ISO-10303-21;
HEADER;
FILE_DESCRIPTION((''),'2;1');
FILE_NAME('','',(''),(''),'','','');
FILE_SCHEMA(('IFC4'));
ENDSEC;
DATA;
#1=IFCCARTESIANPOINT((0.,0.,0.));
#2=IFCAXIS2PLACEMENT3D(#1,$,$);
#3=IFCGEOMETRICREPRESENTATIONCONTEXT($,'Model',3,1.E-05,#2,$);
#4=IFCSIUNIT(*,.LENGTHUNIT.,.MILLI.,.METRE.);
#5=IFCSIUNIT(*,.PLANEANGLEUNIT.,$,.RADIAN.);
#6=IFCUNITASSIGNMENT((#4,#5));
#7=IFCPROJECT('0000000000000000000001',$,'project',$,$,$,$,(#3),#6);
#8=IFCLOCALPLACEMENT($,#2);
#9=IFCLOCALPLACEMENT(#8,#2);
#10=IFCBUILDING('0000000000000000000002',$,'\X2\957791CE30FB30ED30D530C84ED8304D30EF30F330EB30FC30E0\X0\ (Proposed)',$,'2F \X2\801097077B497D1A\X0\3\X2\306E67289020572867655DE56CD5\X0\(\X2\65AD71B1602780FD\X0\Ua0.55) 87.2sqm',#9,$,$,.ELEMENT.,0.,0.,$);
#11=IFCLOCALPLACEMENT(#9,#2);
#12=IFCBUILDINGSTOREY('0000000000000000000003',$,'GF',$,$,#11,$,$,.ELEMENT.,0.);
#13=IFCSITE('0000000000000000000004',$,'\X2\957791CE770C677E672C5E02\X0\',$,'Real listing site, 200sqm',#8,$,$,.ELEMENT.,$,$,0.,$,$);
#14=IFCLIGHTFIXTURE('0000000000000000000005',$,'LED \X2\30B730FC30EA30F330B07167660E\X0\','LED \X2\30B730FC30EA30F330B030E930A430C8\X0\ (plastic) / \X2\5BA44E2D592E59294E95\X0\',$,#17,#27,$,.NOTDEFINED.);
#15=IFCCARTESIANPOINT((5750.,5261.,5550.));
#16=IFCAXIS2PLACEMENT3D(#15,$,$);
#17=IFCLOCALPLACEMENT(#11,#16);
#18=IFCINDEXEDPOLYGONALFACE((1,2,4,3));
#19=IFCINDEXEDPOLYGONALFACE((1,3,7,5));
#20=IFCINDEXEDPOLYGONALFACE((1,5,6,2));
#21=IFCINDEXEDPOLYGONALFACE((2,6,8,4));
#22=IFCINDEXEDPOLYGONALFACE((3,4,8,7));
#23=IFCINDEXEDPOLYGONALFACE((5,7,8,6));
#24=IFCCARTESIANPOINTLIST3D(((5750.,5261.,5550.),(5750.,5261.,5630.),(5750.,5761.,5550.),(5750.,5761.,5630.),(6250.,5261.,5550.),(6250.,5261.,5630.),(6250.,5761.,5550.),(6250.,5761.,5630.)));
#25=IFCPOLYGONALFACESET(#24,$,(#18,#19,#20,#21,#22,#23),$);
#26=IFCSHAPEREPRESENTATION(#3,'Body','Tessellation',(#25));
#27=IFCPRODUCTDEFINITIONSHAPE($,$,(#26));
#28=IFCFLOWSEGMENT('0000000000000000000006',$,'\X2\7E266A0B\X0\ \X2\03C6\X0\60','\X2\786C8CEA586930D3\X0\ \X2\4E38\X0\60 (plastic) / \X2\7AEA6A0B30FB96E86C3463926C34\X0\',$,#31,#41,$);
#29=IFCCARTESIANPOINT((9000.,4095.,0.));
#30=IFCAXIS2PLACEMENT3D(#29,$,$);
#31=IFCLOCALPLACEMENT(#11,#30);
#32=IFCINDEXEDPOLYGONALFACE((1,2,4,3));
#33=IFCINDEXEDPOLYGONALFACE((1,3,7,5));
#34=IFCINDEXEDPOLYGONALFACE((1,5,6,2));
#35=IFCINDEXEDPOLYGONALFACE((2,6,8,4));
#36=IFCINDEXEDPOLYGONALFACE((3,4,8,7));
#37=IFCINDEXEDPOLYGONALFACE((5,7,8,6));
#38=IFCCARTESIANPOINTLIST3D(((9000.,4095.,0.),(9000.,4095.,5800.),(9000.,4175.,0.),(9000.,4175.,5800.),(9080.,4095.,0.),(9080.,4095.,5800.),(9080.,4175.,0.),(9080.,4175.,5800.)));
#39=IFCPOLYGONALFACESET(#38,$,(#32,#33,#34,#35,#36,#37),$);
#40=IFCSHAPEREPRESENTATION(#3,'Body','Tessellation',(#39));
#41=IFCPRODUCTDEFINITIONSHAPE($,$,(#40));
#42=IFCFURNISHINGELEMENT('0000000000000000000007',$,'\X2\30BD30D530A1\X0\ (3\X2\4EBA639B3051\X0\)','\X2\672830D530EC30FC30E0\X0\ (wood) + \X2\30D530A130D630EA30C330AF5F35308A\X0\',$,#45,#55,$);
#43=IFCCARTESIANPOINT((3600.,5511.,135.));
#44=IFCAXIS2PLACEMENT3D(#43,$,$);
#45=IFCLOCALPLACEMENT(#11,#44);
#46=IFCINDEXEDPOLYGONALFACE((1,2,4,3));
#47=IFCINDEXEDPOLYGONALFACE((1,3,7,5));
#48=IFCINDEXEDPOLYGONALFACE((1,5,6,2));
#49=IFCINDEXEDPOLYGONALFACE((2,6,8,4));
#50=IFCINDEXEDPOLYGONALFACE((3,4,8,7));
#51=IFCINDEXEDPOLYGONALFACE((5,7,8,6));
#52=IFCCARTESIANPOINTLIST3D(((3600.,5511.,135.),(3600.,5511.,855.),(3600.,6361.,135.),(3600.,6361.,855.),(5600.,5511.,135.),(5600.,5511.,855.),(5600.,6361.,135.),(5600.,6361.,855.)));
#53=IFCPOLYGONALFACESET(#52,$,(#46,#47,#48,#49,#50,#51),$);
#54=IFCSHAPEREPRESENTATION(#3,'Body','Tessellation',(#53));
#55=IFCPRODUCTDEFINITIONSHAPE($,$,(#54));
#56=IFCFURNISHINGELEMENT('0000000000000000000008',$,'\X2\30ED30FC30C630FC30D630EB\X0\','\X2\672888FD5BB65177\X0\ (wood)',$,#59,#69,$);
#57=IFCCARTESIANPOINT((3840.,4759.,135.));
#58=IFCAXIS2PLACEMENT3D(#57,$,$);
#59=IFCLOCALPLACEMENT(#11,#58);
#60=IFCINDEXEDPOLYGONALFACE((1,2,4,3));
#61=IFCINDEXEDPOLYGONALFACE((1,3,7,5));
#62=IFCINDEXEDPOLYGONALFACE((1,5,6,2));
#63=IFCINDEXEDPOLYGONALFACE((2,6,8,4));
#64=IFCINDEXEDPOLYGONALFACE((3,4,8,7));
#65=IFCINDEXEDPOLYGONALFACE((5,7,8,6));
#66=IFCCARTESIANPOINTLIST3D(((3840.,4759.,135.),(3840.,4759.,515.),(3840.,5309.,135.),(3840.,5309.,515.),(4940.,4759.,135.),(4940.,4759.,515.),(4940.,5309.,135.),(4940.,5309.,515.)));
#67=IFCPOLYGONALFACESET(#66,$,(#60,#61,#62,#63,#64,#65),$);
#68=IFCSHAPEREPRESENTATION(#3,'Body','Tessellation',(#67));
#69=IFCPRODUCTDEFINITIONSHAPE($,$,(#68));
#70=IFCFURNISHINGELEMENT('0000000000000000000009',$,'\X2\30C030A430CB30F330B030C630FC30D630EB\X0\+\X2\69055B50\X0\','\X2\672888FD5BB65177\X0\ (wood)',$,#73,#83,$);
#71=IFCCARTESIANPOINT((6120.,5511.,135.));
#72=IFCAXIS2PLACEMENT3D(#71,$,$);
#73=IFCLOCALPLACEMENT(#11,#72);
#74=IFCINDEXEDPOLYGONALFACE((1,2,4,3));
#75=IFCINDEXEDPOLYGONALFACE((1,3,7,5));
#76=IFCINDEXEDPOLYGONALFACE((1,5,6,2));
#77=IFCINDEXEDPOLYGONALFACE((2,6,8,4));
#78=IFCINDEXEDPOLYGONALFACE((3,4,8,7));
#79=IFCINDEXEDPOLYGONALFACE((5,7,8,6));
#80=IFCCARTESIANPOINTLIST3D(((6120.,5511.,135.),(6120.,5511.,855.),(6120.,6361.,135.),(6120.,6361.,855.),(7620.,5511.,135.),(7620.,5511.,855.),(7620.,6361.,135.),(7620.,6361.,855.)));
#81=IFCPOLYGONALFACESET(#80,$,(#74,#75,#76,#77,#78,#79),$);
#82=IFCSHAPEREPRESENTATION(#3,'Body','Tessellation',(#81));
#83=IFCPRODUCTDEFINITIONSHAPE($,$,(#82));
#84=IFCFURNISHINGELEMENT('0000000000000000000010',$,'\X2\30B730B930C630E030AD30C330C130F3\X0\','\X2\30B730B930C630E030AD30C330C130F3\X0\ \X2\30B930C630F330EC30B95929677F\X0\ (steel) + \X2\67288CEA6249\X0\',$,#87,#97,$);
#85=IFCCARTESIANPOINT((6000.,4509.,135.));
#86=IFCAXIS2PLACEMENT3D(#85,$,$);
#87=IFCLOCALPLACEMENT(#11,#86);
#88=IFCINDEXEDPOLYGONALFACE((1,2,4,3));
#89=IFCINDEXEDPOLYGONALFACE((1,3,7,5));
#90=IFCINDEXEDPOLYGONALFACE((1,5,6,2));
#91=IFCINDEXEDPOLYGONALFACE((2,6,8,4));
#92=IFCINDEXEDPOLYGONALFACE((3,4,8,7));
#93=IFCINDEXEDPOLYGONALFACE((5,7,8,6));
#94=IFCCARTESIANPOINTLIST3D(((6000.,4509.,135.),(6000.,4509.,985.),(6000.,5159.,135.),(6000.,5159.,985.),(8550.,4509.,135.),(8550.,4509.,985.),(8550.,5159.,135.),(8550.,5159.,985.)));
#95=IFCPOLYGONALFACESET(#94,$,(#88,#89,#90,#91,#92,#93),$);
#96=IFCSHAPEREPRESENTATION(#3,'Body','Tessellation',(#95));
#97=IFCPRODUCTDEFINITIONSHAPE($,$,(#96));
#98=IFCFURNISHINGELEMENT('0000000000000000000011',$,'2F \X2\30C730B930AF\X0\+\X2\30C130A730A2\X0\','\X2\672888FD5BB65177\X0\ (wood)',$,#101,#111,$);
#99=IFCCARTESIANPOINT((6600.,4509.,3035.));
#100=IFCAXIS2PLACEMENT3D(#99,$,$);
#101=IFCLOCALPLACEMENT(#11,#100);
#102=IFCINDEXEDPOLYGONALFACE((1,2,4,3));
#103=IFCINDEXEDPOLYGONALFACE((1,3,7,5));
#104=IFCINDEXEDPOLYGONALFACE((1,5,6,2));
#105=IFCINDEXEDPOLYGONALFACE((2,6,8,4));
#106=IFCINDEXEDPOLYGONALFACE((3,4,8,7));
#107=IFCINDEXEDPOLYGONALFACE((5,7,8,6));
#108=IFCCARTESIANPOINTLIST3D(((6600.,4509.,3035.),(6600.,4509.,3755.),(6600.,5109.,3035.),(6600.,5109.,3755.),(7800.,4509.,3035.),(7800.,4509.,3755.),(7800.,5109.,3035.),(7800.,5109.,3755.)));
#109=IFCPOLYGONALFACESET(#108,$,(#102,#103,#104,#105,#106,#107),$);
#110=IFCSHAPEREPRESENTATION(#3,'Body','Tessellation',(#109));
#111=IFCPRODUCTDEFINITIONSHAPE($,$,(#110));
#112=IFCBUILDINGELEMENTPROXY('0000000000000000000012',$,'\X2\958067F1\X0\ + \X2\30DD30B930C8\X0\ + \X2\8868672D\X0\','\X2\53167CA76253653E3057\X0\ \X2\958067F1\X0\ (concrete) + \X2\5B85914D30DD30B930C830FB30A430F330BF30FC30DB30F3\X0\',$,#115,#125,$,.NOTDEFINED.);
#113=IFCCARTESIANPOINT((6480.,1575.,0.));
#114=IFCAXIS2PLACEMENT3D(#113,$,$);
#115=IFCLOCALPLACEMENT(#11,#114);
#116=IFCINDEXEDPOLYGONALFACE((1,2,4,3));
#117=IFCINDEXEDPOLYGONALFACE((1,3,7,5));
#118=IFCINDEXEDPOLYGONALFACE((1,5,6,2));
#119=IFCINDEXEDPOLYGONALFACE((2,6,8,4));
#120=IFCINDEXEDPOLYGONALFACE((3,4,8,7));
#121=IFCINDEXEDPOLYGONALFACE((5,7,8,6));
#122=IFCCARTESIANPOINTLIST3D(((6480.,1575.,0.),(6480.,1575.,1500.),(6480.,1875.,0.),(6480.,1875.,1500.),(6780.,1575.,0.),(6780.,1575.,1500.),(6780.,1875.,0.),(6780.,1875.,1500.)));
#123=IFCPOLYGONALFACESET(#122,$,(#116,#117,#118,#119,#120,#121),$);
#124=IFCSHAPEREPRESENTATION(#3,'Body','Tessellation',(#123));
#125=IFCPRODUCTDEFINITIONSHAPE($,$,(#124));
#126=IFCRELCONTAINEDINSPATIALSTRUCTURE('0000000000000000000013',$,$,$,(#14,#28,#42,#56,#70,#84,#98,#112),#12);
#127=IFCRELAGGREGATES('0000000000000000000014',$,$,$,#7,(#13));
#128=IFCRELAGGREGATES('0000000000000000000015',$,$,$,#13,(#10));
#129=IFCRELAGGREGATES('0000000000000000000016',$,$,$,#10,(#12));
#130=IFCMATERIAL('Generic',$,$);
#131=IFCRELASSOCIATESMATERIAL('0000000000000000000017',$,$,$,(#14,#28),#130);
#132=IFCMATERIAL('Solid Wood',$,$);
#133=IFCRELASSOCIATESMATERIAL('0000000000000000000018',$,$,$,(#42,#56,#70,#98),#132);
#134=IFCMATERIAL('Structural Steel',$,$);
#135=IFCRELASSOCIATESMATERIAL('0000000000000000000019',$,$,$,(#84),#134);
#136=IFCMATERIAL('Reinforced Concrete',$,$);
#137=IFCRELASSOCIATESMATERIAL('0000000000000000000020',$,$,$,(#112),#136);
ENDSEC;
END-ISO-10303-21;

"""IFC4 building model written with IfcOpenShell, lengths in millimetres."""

from ifc_helpers import new_model, si_unit, frame, frame_2d, origin, place, context, project, spatial, rectangle, extrude, material, element, save


model = new_model("IFC4")

# Units and contexts
model_context = context("Model", 3, precision=1e-05, world=origin())
ifc_project = project(units=[si_unit("LENGTHUNIT", "METRE", prefix="MILLI"), si_unit("PLANEANGLEUNIT", "RADIAN")], contexts=[model_context])

# Site, building, storey
site_placement = place(None, origin())
site = spatial("IfcSite", under=ifc_project, at=site_placement, Name="長野県松本市", ObjectType="Real listing site, 200sqm", CompositionType="ELEMENT", RefElevation=0.0)
building_placement = place(site_placement, origin())
building = spatial("IfcBuilding", under=site, at=building_placement, Name="長野・ロフト付きワンルーム (Proposed)", ObjectType="2F 耐震等級3の木造在来工法(断熱性能Ua0.55) 87.2sqm", CompositionType="ELEMENT", ElevationOfRefHeight=0.0, ElevationOfTerrain=0.0)
storey_placement = place(building_placement, origin())
storey = spatial("IfcBuildingStorey", under=building, at=storey_placement, Name="GF", CompositionType="ELEMENT", Elevation=0.0)

# Shared definitions
ifc_material_1 = material(Name="Solid Wood")

# Shared definitions
ifc_material_2 = material(Name="Reinforced Concrete")

# Shared definitions
ifc_material_3 = material(Name="Structural Steel")

# Shared definitions
ifc_material_4 = material(Name="Generic")

# Light fixture
light_fixture_1_placement = place(storey_placement, frame((5750.0, 5261.0, 5550.0)))
element("IfcLightFixture", 1, at=light_fixture_1_placement, inside=storey, material=ifc_material_4, Name="LED シーリング照明", Description="LED シーリングライト (plastic) / 室中央天井", PredefinedType="NOTDEFINED", context=model_context, shape_type="SweptSolid", body=[
    extrude(rectangle(XDim=500.0, YDim=500.0, at=frame_2d((250.0, 250.0))), frame((5750.0, 5261.0, 5550.0)), (0.0, 0.0, 1.0), 80.0),
])

# Flow segment
flow_segment_placement = place(storey_placement, frame((9000.0, 4095.0, 0.0)))
element("IfcFlowSegment", 2, at=flow_segment_placement, inside=storey, material=ifc_material_4, Name="縦樋 φ60", Description="硬質塩ビ 丸60 (plastic) / 竪樋・雨水排水", context=model_context, shape_type="SweptSolid", body=[
    extrude(rectangle(XDim=80.0, YDim=80.0, at=frame_2d((40.0, 40.0))), frame((9000.0, 4095.0, 0.0)), (0.0, 0.0, 1.0), 5800.0),
])

# Furnishing elements
furnishing_1_placement = place(storey_placement, frame((3600.0, 5511.0, 135.0)))
element("IfcFurnishingElement", 3, at=furnishing_1_placement, inside=storey, material=ifc_material_1, Name="ソファ (3人掛け)", Description="木フレーム (wood) + ファブリック張り", context=model_context, shape_type="SweptSolid", body=[
    extrude(rectangle(XDim=2000.0, YDim=850.0, at=frame_2d((1000.0, 425.0))), frame((3600.0, 5511.0, 135.0)), (0.0, 0.0, 1.0), 720.0),
])
furnishing_2_placement = place(storey_placement, frame((3840.0, 4759.0, 135.0)))
element("IfcFurnishingElement", 4, at=furnishing_2_placement, inside=storey, material=ifc_material_1, Name="ローテーブル", Description="木製家具 (wood)", context=model_context, shape_type="SweptSolid", body=[
    extrude(rectangle(XDim=1100.0, YDim=550.0, at=frame_2d((550.0, 275.0))), frame((3840.0, 4759.0, 135.0)), (0.0, 0.0, 1.0), 380.0),
])
furnishing_3_placement = place(storey_placement, frame((6120.0, 5511.0, 135.0)))
element("IfcFurnishingElement", 5, at=furnishing_3_placement, inside=storey, material=ifc_material_1, Name="ダイニングテーブル+椅子", Description="木製家具 (wood)", context=model_context, shape_type="SweptSolid", body=[
    extrude(rectangle(XDim=1500.0, YDim=850.0, at=frame_2d((750.0, 425.0))), frame((6120.0, 5511.0, 135.0)), (0.0, 0.0, 1.0), 720.0),
])
furnishing_4_placement = place(storey_placement, frame((6000.0, 4509.0, 135.0)))
element("IfcFurnishingElement", 6, at=furnishing_4_placement, inside=storey, material=ifc_material_3, Name="システムキッチン", Description="システムキッチン ステンレス天板 (steel) + 木質扉", context=model_context, shape_type="SweptSolid", body=[
    extrude(rectangle(XDim=2550.0, YDim=650.0, at=frame_2d((1275.0, 325.0))), frame((6000.0, 4509.0, 135.0)), (0.0, 0.0, 1.0), 850.0),
])
furnishing_5_placement = place(storey_placement, frame((6600.0, 4509.0, 3035.0)))
element("IfcFurnishingElement", 7, at=furnishing_5_placement, inside=storey, material=ifc_material_1, Name="2F デスク+チェア", Description="木製家具 (wood)", context=model_context, shape_type="SweptSolid", body=[
    extrude(rectangle(XDim=1200.0, YDim=600.0, at=frame_2d((600.0, 300.0))), frame((6600.0, 4509.0, 3035.0)), (0.0, 0.0, 1.0), 720.0),
])

# Building element proxy
proxy_placement = place(storey_placement, frame((6480.0, 1575.0, 0.0)))
element("IfcBuildingElementProxy", 8, at=proxy_placement, inside=storey, material=ifc_material_2, Name="門柱 + ポスト + 表札", Description="化粧打放し 門柱 (concrete) + 宅配ポスト・インターホン", PredefinedType="NOTDEFINED", context=model_context, shape_type="SweptSolid", body=[
    extrude(rectangle(XDim=300.0, YDim=300.0, at=frame_2d((150.0, 150.0))), frame((6480.0, 1575.0, 0.0)), (0.0, 0.0, 1.0), 1500.0),
])

save(model, "model.ifc")
